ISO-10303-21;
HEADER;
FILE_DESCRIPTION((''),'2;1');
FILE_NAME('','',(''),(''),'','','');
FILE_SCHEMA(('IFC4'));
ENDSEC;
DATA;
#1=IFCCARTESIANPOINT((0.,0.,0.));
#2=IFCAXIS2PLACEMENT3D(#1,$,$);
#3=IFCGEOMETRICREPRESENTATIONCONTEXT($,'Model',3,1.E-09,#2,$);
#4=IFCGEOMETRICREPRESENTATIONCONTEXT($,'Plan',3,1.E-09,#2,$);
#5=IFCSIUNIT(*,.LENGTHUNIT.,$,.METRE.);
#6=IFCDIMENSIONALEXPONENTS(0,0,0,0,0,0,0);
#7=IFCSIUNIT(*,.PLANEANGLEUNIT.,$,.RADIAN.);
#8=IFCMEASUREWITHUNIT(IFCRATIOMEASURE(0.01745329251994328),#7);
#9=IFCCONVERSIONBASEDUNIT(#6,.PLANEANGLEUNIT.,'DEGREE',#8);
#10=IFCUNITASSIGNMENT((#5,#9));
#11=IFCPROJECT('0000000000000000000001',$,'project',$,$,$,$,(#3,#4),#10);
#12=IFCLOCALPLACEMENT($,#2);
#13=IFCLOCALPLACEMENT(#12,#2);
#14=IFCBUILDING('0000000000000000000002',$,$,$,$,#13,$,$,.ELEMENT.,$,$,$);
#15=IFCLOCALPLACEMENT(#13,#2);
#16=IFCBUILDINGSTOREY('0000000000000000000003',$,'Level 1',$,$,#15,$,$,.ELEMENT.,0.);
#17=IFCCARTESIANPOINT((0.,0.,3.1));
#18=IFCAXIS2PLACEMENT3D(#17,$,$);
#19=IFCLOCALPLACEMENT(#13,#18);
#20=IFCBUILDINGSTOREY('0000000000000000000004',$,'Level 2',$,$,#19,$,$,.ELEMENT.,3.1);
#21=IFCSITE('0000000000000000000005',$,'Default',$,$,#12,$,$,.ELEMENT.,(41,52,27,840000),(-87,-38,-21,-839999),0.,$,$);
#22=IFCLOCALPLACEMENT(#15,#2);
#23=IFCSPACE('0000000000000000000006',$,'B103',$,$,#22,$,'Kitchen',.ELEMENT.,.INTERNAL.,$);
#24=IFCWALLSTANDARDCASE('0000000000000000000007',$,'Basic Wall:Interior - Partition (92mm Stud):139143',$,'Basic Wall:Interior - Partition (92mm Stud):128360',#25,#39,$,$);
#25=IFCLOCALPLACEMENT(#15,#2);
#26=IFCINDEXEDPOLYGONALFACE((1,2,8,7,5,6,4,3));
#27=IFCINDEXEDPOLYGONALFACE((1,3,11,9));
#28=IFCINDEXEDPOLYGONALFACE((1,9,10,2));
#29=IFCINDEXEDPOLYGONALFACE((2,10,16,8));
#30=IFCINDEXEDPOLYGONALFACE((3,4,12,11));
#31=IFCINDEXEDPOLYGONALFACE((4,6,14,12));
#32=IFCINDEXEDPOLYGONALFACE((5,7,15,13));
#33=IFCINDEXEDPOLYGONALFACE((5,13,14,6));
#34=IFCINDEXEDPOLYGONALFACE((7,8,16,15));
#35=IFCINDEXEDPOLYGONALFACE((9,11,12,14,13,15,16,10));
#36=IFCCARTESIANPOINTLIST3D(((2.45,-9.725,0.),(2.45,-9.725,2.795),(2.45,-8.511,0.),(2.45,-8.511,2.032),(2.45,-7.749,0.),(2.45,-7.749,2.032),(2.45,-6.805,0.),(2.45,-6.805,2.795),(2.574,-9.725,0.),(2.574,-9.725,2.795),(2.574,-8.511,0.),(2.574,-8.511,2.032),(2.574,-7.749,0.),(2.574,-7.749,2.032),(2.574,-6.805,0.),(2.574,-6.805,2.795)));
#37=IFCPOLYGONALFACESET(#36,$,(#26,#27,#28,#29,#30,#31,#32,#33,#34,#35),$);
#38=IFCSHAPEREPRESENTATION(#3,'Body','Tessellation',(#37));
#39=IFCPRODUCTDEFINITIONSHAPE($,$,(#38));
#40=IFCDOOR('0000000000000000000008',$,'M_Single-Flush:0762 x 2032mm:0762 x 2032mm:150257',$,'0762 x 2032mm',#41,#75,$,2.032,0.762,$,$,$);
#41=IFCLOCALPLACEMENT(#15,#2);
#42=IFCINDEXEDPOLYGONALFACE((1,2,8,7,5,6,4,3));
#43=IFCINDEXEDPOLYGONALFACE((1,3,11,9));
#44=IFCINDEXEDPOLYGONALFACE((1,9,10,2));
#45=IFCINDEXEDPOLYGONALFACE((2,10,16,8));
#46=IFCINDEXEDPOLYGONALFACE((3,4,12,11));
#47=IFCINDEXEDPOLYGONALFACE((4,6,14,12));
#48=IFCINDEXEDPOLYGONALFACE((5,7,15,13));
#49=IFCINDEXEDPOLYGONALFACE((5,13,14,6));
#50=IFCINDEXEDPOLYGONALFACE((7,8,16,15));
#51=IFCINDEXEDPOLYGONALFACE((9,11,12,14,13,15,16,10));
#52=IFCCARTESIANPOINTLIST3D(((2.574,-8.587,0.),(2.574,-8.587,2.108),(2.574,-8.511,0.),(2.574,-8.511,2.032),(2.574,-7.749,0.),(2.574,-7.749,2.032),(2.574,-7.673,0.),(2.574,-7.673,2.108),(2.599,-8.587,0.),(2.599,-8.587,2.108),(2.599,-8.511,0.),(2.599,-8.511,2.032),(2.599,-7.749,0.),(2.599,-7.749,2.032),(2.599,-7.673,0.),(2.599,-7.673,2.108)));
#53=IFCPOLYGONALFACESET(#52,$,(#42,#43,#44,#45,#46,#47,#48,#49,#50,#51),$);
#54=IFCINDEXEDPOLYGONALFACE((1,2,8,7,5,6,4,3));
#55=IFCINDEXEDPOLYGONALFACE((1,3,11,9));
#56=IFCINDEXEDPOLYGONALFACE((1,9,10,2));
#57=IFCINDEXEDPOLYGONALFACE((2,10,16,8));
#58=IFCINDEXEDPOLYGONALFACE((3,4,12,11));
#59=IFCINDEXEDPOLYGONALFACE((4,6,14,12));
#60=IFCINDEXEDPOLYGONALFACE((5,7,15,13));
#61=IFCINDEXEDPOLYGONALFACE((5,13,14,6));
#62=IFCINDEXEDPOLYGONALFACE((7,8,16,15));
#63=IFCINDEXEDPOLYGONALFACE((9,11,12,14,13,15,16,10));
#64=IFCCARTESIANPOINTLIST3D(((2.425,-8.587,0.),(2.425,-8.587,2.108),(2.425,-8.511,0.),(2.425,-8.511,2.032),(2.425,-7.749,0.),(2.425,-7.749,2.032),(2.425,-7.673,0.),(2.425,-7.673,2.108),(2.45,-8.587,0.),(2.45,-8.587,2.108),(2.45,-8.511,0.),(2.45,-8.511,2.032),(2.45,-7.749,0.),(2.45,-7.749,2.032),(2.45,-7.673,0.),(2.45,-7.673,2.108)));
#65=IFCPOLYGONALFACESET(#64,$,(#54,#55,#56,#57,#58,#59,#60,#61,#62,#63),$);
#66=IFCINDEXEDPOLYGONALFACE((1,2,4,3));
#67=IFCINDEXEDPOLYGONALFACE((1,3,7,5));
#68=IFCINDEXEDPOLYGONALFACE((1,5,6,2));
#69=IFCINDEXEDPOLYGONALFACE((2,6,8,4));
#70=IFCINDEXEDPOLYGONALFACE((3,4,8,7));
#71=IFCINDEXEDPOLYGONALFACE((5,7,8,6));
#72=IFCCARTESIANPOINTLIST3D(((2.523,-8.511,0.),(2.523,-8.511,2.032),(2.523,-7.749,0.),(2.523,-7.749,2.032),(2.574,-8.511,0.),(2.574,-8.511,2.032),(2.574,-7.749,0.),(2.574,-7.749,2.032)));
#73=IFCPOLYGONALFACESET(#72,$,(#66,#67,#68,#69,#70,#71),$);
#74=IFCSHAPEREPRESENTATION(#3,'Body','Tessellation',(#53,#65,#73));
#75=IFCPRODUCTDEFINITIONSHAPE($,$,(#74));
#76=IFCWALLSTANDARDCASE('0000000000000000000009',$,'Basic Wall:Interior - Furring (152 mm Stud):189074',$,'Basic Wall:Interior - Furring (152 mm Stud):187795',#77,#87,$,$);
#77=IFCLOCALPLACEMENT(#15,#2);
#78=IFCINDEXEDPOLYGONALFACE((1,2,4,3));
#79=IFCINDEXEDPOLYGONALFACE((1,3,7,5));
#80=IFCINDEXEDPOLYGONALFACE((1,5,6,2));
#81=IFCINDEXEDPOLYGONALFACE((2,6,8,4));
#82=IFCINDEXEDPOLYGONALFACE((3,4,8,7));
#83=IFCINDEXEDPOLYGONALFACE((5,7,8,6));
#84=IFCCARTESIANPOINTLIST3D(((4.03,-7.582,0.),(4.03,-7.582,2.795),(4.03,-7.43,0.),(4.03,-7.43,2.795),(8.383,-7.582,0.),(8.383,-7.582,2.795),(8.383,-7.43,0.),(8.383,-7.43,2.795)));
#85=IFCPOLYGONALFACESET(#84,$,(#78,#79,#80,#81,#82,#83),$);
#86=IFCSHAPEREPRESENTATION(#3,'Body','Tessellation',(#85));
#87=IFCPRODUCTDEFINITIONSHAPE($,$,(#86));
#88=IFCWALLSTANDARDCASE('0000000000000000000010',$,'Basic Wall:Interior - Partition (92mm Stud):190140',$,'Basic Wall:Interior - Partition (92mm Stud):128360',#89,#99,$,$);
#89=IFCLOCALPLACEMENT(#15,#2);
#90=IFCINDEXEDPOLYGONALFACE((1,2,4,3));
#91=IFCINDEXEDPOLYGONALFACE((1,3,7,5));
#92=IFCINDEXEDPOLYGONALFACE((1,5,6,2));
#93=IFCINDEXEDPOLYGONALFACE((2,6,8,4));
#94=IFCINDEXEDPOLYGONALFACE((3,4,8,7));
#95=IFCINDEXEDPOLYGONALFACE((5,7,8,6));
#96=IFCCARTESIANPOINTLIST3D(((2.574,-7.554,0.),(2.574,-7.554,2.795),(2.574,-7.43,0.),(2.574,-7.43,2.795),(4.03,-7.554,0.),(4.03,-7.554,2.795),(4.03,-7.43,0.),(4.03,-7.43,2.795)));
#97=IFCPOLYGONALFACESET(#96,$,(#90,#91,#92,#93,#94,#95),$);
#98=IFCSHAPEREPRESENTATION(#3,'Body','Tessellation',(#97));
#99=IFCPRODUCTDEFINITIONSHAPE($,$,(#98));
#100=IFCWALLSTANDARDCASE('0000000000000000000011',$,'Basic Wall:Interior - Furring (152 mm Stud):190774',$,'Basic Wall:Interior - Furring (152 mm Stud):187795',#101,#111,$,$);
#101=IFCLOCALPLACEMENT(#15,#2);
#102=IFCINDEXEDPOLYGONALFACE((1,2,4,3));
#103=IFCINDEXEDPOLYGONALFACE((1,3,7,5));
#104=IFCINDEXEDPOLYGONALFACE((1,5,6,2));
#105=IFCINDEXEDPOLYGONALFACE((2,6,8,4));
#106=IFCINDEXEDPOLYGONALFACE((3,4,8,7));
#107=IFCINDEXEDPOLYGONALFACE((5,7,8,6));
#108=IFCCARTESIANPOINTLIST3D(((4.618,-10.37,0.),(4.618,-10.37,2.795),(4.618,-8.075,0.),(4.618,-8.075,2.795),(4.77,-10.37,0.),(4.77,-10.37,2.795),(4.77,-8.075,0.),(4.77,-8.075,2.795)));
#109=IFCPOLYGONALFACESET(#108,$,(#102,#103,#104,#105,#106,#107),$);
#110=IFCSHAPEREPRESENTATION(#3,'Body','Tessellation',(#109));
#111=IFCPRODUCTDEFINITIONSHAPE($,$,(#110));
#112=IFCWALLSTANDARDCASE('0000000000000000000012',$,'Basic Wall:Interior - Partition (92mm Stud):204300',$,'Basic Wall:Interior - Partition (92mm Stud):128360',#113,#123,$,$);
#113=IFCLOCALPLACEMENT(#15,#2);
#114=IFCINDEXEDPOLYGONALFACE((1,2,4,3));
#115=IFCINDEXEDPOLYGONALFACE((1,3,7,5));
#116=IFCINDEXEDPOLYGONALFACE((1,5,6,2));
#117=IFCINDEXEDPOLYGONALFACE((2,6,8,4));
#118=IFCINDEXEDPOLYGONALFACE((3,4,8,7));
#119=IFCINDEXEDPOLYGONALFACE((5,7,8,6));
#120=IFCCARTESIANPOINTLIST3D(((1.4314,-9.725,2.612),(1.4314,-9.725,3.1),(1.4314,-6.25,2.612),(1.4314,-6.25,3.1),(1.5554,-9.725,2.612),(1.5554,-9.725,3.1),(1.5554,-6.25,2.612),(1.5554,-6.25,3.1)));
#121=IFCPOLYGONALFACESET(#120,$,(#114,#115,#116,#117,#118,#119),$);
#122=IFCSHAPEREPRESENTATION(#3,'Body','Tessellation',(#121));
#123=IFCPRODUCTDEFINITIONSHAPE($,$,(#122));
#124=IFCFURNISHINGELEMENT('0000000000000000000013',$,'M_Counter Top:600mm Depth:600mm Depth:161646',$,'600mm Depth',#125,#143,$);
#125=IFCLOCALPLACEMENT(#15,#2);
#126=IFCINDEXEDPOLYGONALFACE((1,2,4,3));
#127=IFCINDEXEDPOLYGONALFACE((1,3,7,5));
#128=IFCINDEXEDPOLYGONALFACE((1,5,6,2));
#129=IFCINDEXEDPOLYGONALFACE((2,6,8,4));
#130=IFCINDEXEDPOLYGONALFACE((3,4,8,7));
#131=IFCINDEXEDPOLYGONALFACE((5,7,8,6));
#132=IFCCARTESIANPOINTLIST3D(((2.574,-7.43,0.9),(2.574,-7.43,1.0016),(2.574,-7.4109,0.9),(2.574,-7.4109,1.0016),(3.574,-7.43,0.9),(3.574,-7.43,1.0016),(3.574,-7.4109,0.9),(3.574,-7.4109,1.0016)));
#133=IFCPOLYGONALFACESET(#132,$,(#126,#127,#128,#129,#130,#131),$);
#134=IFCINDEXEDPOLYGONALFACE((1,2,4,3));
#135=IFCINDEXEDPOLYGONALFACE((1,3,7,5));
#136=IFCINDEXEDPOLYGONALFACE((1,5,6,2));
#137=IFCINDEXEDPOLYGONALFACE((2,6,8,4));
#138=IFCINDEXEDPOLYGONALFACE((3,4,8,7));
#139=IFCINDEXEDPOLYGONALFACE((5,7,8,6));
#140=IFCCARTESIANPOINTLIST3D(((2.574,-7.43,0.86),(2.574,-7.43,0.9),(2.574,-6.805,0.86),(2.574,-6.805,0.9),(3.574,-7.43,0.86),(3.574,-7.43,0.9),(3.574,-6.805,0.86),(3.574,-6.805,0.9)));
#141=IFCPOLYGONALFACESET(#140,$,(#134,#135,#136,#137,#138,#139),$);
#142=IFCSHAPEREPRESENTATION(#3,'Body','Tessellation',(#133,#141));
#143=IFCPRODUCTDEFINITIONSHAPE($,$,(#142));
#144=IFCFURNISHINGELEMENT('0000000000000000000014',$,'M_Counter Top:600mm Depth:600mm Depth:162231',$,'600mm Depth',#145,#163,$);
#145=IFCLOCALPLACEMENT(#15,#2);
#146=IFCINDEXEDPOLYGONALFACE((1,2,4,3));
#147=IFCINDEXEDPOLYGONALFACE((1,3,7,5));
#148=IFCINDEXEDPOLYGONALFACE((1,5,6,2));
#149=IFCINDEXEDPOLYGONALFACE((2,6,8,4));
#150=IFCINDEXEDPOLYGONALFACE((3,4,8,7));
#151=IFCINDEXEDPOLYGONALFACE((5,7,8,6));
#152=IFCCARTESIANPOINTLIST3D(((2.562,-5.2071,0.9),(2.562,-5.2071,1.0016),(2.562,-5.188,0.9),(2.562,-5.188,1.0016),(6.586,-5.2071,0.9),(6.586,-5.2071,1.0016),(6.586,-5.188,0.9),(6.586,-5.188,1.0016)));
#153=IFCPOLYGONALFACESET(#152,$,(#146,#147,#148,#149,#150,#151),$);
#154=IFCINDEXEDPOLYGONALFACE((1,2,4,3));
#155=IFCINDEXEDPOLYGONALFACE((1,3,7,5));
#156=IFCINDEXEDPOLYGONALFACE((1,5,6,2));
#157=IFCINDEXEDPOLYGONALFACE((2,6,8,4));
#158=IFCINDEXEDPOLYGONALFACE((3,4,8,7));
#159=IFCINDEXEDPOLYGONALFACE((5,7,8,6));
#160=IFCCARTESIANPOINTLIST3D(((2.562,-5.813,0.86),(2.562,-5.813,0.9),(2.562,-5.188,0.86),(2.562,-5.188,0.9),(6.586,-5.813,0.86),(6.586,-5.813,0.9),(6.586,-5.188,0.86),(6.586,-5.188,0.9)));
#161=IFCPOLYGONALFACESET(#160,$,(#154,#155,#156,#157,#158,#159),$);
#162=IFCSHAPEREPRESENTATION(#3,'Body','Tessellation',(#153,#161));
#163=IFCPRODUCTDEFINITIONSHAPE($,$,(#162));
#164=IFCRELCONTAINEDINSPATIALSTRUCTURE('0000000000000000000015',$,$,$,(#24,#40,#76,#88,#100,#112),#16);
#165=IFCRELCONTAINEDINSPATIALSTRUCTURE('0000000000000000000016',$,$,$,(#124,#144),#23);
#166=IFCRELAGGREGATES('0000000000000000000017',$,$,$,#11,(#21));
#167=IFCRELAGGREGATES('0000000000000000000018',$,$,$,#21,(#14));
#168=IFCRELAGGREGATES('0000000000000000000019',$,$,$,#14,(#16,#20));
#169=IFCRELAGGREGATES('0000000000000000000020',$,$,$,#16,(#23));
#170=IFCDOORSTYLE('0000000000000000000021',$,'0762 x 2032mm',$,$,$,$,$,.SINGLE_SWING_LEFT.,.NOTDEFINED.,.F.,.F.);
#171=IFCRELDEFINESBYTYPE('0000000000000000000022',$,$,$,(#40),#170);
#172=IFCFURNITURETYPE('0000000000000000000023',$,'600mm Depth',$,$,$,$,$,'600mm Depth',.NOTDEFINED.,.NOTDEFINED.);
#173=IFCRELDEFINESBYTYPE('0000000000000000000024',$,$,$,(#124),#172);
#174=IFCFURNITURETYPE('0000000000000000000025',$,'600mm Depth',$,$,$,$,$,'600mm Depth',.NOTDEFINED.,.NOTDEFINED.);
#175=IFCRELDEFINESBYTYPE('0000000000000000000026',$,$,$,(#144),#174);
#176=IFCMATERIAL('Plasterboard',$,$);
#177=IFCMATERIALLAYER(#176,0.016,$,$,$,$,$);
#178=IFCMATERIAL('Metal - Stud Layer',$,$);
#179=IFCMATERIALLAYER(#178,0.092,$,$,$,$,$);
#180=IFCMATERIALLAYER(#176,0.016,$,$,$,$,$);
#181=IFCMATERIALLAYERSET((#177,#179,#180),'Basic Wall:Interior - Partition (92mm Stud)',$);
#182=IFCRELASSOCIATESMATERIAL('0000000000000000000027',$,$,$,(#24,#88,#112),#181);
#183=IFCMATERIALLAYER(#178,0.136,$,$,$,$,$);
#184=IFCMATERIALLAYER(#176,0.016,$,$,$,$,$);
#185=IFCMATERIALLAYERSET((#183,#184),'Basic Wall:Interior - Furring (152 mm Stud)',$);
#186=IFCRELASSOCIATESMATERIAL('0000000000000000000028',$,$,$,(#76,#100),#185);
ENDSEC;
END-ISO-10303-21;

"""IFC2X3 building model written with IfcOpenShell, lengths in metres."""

from ifc_helpers import new_model, entity, si_unit, converted_unit, frame, frame_2d, origin, origin_2d_with_axis, place, context, project, spatial, polyline, rectangle, outline, extrude, clip, bounded_halfspace, source, transform, mapped, material, layer, layer_set, layer_usage, type_object, type_shapes, element, fill, save


model = new_model("IFC2X3")

# Units and contexts
model_context = context("Model", 3, precision=1e-09, world=origin())
plan_context = context("Plan", 3, precision=1e-09, world=origin())
ifc_project = project(units=[si_unit("LENGTHUNIT", "METRE"), converted_unit("PLANEANGLEUNIT", "DEGREE", entity("IfcRatioMeasure", 0.01745329251994328), si_unit("PLANEANGLEUNIT", "RADIAN"), dimensions=[0, 0, 0, 0, 0, 0, 0])], contexts=[model_context, plan_context])

# Site, building, storey
site_placement = place(None, origin())
site = spatial("IfcSite", under=ifc_project, at=site_placement, Name="Default", CompositionType="ELEMENT", RefLatitude=(41, 52, 27, 840000), RefLongitude=(-87, -38, -21, -839999), RefElevation=0.0)
building_placement = place(site_placement, origin())
building = spatial("IfcBuilding", under=site, at=building_placement, CompositionType="ELEMENT")
storey_1_placement = place(building_placement, origin())
storey_1 = spatial("IfcBuildingStorey", under=building, at=storey_1_placement, Name="Level 1", CompositionType="ELEMENT", Elevation=0.0)

# Shared definitions
ifc_material_1 = material(Name="Metal - Stud Layer")
ifc_material_2 = material(Name="Plasterboard")

# Shared definitions
ifc_layer_1 = layer(ifc_material_2, 0.016)
ifc_layer_2 = layer(ifc_material_1, 0.092)
ifc_layer_3 = layer(ifc_material_2, 0.016)
ifc_layer_set_1 = layer_set([ifc_layer_1, ifc_layer_2, ifc_layer_3], Name="Basic Wall:Interior - Partition (92mm Stud)")

# Wall, opening, door
ifc_layer_usage_1 = layer_usage(ifc_layer_set_1, "AXIS2", "NEGATIVE", 0.062)
wall_1_placement = place(storey_1_placement, frame((2.512, -6.805, 0.0), z_axis=(0.0, 0.0, 1.0), x_axis=(0.0, -1.0, 0.0)))
wall_1 = element("IfcWallStandardCase", 1, at=wall_1_placement, inside=storey_1, material=ifc_layer_usage_1, Name="Basic Wall:Interior - Partition (92mm Stud):139143", ObjectType="Basic Wall:Interior - Partition (92mm Stud):128360", context=model_context, shape_type="SweptSolid", body=[
    extrude(rectangle(XDim=2.92, YDim=0.124, at=frame_2d((1.46, 0.0), x_axis=(-1.0, 0.0))), origin(), (0.0, 0.0, 1.0), 2.795),
])
opening_1_placement = place(wall_1_placement, frame((0.944, -0.062, 0.0)))
opening_1 = element("IfcOpeningElement", 2, at=opening_1_placement, cuts=wall_1, ObjectType="Opening", context=model_context, shape_type="SweptSolid", body=[
    extrude(rectangle(XDim=0.762, YDim=2.032, at=frame_2d((1.016, 0.381), x_axis=(0.0, -1.0))), frame((0.0, 0.0, 0.0), z_axis=(0.0, 1.0, 0.0), x_axis=(0.0, 0.0, 1.0)), (0.0, 0.0, 1.0), 0.124),
])
door_style_1 = type_object("IfcDoorStyle", Name="0762 x 2032mm", ConstructionType="NOTDEFINED", OperationType="SINGLE_SWING_LEFT", ParameterTakesPrecedence=False, Sizeable=False)
shared_shape_1 = source(origin(), model_context, "Body", "SweptSolid", [
    extrude(outline(polyline([(-0.457, -1.073), (0.457, -1.073), (0.457, 1.035), (0.381, 1.035), (0.381, -0.997), (-0.381, -0.997), (-0.381, 1.035), (-0.457, 1.035), (-0.457, -1.073)])), frame((0.381, 0.149, 1.035), z_axis=(0.0, -1.0, 0.0), x_axis=(-1.0, 0.0, 0.0)), (0.0, 0.0, 1.0), 0.025),
    extrude(outline(polyline([(-1.073, -0.457), (1.035, -0.457), (1.035, -0.381), (-0.997, -0.381), (-0.997, 0.381), (1.035, 0.381), (1.035, 0.457), (-1.073, 0.457), (-1.073, -0.457)])), frame((0.381, 0.0, 1.035), z_axis=(0.0, -1.0, 0.0), x_axis=(0.0, 0.0, -1.0)), (0.0, 0.0, 1.0), 0.025),
    extrude(rectangle(XDim=0.762, YDim=0.051, at=origin_2d_with_axis()), frame((0.381, 0.0985, 0.0)), (0.0, 0.0, 1.0), 2.032),
])
type_shapes(door_style_1, [shared_shape_1])
door_1_placement = place(opening_1_placement, origin())
door_1 = element("IfcDoor", 3, at=door_1_placement, inside=storey_1, type_object=door_style_1, Name="M_Single-Flush:0762 x 2032mm:0762 x 2032mm:150257", ObjectType="0762 x 2032mm", OverallHeight=2.032, OverallWidth=0.762, context=model_context, shape_type="MappedRepresentation", body=[
    mapped(shared_shape_1, transform((0.0, 0.0, 0.0), scale=1.0)),
])
fill(opening_1, door_1)

# Shared definitions
storey_2_placement = place(building_placement, frame((0.0, 0.0, 3.1)))
storey_2 = spatial("IfcBuildingStorey", under=building, at=storey_2_placement, Name="Level 2", CompositionType="ELEMENT", Elevation=3.1)

# Walls
ifc_layer_4 = layer(ifc_material_1, 0.136)
ifc_layer_5 = layer(ifc_material_2, 0.016)
ifc_layer_set_2 = layer_set([ifc_layer_4, ifc_layer_5], Name="Basic Wall:Interior - Furring (152 mm Stud)")
ifc_layer_usage_2 = layer_usage(ifc_layer_set_2, "AXIS2", "NEGATIVE", 0.076)
wall_2_placement = place(storey_1_placement, frame((8.383, -7.506, 0.0), z_axis=(0.0, 0.0, 1.0), x_axis=(-1.0, 0.0, 0.0)))
element("IfcWallStandardCase", 4, at=wall_2_placement, inside=storey_1, material=ifc_layer_usage_2, Name="Basic Wall:Interior - Furring (152 mm Stud):189074", ObjectType="Basic Wall:Interior - Furring (152 mm Stud):187795", context=model_context, shape_type="Clipping", body=[
    clip(extrude(rectangle(XDim=4.353, YDim=0.152, at=frame_2d((2.1765, 0.0), x_axis=(-1.0, 0.0))), origin(), (0.0, 0.0, 1.0), 2.795), bounded_halfspace(frame((0.0, -0.076, 2.795), z_axis=(0.0, 0.0, -1.0), x_axis=(0.0, 1.0, 0.0)), True, frame((0.0, -0.076, 2.795)), polyline([(0.0, 0.0), (3.708, 0.0), (3.708, 0.152), (0.0, 0.152), (0.0, 0.0)]))),
])
ifc_layer_usage_3 = layer_usage(ifc_layer_set_1, "AXIS2", "NEGATIVE", 0.062)
wall_3_placement = place(storey_1_placement, frame((4.03, -7.492, 0.0), z_axis=(0.0, 0.0, 1.0), x_axis=(-1.0, 0.0, 0.0)))
element("IfcWallStandardCase", 5, at=wall_3_placement, inside=storey_1, material=ifc_layer_usage_3, Name="Basic Wall:Interior - Partition (92mm Stud):190140", ObjectType="Basic Wall:Interior - Partition (92mm Stud):128360", context=model_context, shape_type="SweptSolid", body=[
    extrude(rectangle(XDim=1.456, YDim=0.124, at=frame_2d((0.728, 0.0), x_axis=(-1.0, 0.0))), origin(), (0.0, 0.0, 1.0), 2.795),
])
ifc_layer_usage_4 = layer_usage(ifc_layer_set_2, "AXIS2", "POSITIVE", -0.076)
wall_4_placement = place(storey_1_placement, frame((4.694, -8.075, 0.0), z_axis=(0.0, 0.0, 1.0), x_axis=(0.0, -1.0, 0.0)))
element("IfcWallStandardCase", 6, at=wall_4_placement, inside=storey_1, material=ifc_layer_usage_4, Name="Basic Wall:Interior - Furring (152 mm Stud):190774", ObjectType="Basic Wall:Interior - Furring (152 mm Stud):187795", context=model_context, shape_type="SweptSolid", body=[
    extrude(rectangle(XDim=2.295, YDim=0.152, at=frame_2d((1.1475, 0.0), x_axis=(-1.0, 0.0))), origin(), (0.0, 0.0, 1.0), 2.795),
])
ifc_layer_usage_5 = layer_usage(ifc_layer_set_1, "AXIS2", "NEGATIVE", 0.062)
wall_5_placement = place(storey_1_placement, frame((1.4934, -6.25, 2.612), z_axis=(0.0, 0.0, 1.0), x_axis=(0.0, -1.0, 0.0)))
element("IfcWallStandardCase", 7, at=wall_5_placement, inside=storey_1, material=ifc_layer_usage_5, Name="Basic Wall:Interior - Partition (92mm Stud):204300", ObjectType="Basic Wall:Interior - Partition (92mm Stud):128360", context=model_context, shape_type="SweptSolid", body=[
    extrude(rectangle(XDim=3.475, YDim=0.124, at=frame_2d((1.7375, 0.0), x_axis=(-1.0, 0.0))), origin(), (0.0, 0.0, 1.0), 0.488),
])

# Shared definitions
space_1_placement = place(storey_1_placement, origin())
space_1 = spatial("IfcSpace", under=storey_1, at=space_1_placement, Name="B103", LongName="Kitchen", CompositionType="ELEMENT", InteriorOrExteriorSpace="INTERNAL")

# Furnishing elements
furniture_type_1 = type_object("IfcFurnitureType", Name="600mm Depth", ElementType="600mm Depth", AssemblyPlace="NOTDEFINED")
shared_shape_2 = source(origin(), model_context, "Body", "SweptSolid", [
    extrude(rectangle(XDim=0.0191, YDim=1.0, at=origin_2d_with_axis()), frame((-0.7005, -0.0095, 0.9), z_axis=(0.0, 0.0, 1.0), x_axis=(0.0, -1.0, 0.0)), (0.0, 0.0, 1.0), 0.1016),
    extrude(rectangle(XDim=1.0, YDim=0.625, at=origin_2d_with_axis()), frame((-0.7005, -0.3125, 0.86), z_axis=(0.0, 0.0, 1.0), x_axis=(-1.0, 0.0, 0.0)), (0.0, 0.0, 1.0), 0.04),
])
type_shapes(furniture_type_1, [shared_shape_2])
furnishing_1_placement = place(space_1_placement, frame((2.3735, -7.43, 0.0), z_axis=(0.0, 0.0, 1.0), x_axis=(-1.0, 0.0, 0.0)))
element("IfcFurnishingElement", 8, at=furnishing_1_placement, inside=space_1, type_object=furniture_type_1, Name="M_Counter Top:600mm Depth:600mm Depth:161646", ObjectType="600mm Depth", context=model_context, shape_type="MappedRepresentation", body=[
    mapped(shared_shape_2, transform((0.0, 0.0, 0.0), scale=1.0)),
])
furniture_type_2 = type_object("IfcFurnitureType", Name="600mm Depth", ElementType="600mm Depth", AssemblyPlace="NOTDEFINED")
shared_shape_3 = source(origin(), model_context, "Body", "SweptSolid", [
    extrude(rectangle(XDim=0.0191, YDim=4.024, at=origin_2d_with_axis()), frame((0.8115, -0.0095, 0.9), z_axis=(0.0, 0.0, 1.0), x_axis=(0.0, -1.0, 0.0)), (0.0, 0.0, 1.0), 0.1016),
    extrude(rectangle(XDim=4.024, YDim=0.625, at=origin_2d_with_axis()), frame((0.8115, -0.3125, 0.86), z_axis=(0.0, 0.0, 1.0), x_axis=(-1.0, 0.0, 0.0)), (0.0, 0.0, 1.0), 0.04),
])
type_shapes(furniture_type_2, [shared_shape_3])
furnishing_2_placement = place(space_1_placement, frame((3.7625, -5.188, 0.0)))
element("IfcFurnishingElement", 9, at=furnishing_2_placement, inside=space_1, type_object=furniture_type_2, Name="M_Counter Top:600mm Depth:600mm Depth:162231", ObjectType="600mm Depth", context=model_context, shape_type="MappedRepresentation", body=[
    mapped(shared_shape_3, transform((0.0, 0.0, 0.0), scale=1.0)),
])

save(model, "model.ifc")
